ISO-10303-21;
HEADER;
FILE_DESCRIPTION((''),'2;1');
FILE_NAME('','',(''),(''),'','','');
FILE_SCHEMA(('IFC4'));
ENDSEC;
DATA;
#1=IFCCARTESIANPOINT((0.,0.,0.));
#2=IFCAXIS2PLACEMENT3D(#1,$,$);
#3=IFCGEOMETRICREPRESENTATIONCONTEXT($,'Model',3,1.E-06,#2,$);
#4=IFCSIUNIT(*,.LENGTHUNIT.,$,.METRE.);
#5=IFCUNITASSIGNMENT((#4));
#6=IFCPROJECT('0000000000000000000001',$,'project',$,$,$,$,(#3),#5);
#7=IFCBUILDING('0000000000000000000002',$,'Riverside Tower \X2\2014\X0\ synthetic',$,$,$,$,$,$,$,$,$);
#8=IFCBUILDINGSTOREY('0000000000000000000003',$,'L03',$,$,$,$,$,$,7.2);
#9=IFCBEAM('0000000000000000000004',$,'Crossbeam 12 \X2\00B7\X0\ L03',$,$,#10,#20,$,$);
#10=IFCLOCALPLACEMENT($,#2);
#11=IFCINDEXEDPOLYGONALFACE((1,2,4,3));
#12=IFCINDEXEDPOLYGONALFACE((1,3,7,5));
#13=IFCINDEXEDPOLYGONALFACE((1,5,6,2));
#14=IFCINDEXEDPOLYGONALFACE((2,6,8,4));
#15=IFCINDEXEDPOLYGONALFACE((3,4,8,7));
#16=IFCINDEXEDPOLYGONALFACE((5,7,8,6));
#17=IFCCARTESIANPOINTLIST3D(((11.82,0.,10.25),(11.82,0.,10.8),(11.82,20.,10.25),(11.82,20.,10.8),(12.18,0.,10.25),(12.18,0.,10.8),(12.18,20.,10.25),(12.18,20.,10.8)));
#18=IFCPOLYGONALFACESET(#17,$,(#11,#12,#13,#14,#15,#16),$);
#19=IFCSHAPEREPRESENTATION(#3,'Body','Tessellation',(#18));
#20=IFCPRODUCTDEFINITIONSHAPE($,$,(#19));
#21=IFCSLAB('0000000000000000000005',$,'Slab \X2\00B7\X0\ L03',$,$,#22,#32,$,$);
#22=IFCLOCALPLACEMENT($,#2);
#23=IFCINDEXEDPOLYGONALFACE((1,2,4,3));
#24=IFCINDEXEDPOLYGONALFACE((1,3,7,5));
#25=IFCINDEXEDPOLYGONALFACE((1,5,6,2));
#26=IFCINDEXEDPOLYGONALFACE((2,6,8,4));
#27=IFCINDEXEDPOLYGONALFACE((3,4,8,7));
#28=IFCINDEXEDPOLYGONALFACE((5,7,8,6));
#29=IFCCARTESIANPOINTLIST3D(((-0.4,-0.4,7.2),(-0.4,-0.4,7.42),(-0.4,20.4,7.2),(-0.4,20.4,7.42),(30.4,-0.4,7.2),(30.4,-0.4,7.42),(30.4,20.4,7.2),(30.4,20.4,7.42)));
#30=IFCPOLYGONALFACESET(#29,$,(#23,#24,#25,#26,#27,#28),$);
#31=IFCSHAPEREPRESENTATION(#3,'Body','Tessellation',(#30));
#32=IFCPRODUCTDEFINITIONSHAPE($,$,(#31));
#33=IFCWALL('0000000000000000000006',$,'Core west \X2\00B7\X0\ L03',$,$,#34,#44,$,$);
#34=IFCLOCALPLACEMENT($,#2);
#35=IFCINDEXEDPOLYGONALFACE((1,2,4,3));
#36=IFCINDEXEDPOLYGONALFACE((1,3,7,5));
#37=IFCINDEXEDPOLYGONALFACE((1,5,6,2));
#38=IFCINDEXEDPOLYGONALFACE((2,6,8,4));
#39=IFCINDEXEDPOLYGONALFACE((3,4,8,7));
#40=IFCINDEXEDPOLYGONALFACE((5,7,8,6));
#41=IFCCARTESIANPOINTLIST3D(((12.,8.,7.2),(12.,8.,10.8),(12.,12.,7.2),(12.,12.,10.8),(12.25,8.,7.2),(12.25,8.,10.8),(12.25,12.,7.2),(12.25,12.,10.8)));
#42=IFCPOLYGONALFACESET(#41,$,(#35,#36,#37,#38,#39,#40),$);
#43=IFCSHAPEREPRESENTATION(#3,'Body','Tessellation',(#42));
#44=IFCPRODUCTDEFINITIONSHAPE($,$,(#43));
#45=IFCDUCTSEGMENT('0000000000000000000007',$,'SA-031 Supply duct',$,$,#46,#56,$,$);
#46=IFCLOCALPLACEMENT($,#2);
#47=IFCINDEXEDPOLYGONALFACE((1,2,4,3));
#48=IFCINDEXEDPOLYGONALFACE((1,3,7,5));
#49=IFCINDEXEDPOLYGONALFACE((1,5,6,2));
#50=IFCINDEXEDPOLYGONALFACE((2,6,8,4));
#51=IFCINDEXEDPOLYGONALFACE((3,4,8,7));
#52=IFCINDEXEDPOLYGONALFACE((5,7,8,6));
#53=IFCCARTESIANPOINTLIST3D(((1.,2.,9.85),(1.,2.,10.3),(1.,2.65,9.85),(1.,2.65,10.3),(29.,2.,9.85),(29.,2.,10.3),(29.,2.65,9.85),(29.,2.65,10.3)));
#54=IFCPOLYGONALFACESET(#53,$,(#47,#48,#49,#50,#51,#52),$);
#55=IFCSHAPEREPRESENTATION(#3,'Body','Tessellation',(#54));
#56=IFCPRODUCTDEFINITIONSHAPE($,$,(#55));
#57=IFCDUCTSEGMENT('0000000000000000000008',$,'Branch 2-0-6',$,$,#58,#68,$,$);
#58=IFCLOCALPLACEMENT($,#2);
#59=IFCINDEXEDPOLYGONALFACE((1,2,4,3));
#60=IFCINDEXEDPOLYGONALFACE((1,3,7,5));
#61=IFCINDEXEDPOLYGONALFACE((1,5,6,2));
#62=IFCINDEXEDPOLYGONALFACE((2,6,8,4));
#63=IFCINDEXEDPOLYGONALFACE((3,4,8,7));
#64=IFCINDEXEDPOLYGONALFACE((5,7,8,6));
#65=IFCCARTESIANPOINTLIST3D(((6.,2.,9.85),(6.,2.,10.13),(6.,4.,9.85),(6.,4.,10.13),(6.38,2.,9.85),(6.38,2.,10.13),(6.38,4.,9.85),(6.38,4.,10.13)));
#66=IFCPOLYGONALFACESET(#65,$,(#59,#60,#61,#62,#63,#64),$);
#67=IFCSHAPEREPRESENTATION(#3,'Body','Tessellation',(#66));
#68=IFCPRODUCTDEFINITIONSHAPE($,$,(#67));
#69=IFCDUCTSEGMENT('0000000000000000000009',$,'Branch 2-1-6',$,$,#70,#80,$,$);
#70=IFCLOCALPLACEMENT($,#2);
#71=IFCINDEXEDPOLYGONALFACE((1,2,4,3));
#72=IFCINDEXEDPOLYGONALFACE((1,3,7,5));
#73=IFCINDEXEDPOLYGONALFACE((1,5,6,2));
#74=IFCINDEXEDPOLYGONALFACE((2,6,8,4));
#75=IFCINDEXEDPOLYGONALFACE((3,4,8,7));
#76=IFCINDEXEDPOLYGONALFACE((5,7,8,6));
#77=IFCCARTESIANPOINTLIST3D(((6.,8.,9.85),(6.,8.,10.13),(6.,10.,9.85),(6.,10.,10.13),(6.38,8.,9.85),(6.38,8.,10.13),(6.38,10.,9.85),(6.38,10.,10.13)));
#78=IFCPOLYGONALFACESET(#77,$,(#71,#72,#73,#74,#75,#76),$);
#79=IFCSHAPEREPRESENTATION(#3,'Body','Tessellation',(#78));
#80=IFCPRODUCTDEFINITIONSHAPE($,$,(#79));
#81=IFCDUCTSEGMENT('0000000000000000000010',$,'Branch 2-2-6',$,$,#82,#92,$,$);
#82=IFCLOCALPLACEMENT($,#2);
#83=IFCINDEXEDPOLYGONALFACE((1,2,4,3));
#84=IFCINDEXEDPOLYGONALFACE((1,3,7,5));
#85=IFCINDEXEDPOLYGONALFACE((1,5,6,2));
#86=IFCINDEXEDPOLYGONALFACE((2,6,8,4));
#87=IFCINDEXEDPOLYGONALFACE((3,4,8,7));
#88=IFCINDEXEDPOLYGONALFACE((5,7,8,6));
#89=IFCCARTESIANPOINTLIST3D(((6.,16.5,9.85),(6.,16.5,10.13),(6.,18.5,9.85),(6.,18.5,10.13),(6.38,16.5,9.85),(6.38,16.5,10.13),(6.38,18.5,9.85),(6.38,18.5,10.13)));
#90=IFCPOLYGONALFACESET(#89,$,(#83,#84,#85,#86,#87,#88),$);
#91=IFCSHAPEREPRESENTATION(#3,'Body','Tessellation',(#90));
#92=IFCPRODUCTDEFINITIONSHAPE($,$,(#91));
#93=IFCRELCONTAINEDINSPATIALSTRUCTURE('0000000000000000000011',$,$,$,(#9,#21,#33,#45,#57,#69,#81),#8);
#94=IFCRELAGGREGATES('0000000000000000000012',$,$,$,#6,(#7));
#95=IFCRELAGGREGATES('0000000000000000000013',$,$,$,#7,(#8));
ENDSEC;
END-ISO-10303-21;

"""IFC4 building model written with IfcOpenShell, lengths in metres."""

from ifc_helpers import new_model, si_unit, frame, origin, place, context, project, spatial, rectangle, extrude, element, save


model = new_model("IFC4")

# Units and contexts
model_context = context("Model", 3, precision=1e-06, world=origin())
ifc_project = project(units=[si_unit("LENGTHUNIT", "METRE")], contexts=[model_context])

# Building, storey
building = spatial("IfcBuilding", under=ifc_project, Name="Riverside Tower — synthetic")
storey = spatial("IfcBuildingStorey", under=building, Name="L03", Elevation=7.2)

# Beam
for number, where, name in (
    (1, (12.0, 10.0, 10.25), "Crossbeam 12 · L03"),
):
    element("IfcBeam", number, at=place(None, frame(where)), inside=storey, Name=name, context=model_context, shape_type="SweptSolid", body=[
        extrude(rectangle(XDim=0.36, YDim=20.0), origin(), (0.0, 0.0, 1.0), 0.55),
    ])

# Slab
slab_placement = place(None, frame((15.0, 10.0, 7.2)))
element("IfcSlab", 2, at=slab_placement, inside=storey, Name="Slab · L03", context=model_context, shape_type="SweptSolid", body=[
    extrude(rectangle(XDim=30.8, YDim=20.8), origin(), (0.0, 0.0, 1.0), 0.22),
])

# Wall
wall_placement = place(None, frame((12.125, 10.0, 7.2)))
element("IfcWall", 3, at=wall_placement, inside=storey, Name="Core west · L03", context=model_context, shape_type="SweptSolid", body=[
    extrude(rectangle(XDim=0.25, YDim=4.0), origin(), (0.0, 0.0, 1.0), 3.6),
])

# Duct segments
duct_segment_placement = place(None, frame((15.0, 2.325, 9.85)))
element("IfcDuctSegment", 4, at=duct_segment_placement, inside=storey, Name="SA-031 Supply duct", context=model_context, shape_type="SweptSolid", body=[
    extrude(rectangle(XDim=28.0, YDim=0.65), origin(), (0.0, 0.0, 1.0), 0.45),
])
for number, where, name in (
    (5, (6.19, 3.0, 9.85), "Branch 2-0-6"),
    (6, (6.19, 9.0, 9.85), "Branch 2-1-6"),
    (7, (6.19, 17.5, 9.85), "Branch 2-2-6"),
):
    element("IfcDuctSegment", number, at=place(None, frame(where)), inside=storey, Name=name, context=model_context, shape_type="SweptSolid", body=[
        extrude(rectangle(XDim=0.38, YDim=2.0), origin(), (0.0, 0.0, 1.0), 0.28),
    ])

save(model, "model.ifc")
